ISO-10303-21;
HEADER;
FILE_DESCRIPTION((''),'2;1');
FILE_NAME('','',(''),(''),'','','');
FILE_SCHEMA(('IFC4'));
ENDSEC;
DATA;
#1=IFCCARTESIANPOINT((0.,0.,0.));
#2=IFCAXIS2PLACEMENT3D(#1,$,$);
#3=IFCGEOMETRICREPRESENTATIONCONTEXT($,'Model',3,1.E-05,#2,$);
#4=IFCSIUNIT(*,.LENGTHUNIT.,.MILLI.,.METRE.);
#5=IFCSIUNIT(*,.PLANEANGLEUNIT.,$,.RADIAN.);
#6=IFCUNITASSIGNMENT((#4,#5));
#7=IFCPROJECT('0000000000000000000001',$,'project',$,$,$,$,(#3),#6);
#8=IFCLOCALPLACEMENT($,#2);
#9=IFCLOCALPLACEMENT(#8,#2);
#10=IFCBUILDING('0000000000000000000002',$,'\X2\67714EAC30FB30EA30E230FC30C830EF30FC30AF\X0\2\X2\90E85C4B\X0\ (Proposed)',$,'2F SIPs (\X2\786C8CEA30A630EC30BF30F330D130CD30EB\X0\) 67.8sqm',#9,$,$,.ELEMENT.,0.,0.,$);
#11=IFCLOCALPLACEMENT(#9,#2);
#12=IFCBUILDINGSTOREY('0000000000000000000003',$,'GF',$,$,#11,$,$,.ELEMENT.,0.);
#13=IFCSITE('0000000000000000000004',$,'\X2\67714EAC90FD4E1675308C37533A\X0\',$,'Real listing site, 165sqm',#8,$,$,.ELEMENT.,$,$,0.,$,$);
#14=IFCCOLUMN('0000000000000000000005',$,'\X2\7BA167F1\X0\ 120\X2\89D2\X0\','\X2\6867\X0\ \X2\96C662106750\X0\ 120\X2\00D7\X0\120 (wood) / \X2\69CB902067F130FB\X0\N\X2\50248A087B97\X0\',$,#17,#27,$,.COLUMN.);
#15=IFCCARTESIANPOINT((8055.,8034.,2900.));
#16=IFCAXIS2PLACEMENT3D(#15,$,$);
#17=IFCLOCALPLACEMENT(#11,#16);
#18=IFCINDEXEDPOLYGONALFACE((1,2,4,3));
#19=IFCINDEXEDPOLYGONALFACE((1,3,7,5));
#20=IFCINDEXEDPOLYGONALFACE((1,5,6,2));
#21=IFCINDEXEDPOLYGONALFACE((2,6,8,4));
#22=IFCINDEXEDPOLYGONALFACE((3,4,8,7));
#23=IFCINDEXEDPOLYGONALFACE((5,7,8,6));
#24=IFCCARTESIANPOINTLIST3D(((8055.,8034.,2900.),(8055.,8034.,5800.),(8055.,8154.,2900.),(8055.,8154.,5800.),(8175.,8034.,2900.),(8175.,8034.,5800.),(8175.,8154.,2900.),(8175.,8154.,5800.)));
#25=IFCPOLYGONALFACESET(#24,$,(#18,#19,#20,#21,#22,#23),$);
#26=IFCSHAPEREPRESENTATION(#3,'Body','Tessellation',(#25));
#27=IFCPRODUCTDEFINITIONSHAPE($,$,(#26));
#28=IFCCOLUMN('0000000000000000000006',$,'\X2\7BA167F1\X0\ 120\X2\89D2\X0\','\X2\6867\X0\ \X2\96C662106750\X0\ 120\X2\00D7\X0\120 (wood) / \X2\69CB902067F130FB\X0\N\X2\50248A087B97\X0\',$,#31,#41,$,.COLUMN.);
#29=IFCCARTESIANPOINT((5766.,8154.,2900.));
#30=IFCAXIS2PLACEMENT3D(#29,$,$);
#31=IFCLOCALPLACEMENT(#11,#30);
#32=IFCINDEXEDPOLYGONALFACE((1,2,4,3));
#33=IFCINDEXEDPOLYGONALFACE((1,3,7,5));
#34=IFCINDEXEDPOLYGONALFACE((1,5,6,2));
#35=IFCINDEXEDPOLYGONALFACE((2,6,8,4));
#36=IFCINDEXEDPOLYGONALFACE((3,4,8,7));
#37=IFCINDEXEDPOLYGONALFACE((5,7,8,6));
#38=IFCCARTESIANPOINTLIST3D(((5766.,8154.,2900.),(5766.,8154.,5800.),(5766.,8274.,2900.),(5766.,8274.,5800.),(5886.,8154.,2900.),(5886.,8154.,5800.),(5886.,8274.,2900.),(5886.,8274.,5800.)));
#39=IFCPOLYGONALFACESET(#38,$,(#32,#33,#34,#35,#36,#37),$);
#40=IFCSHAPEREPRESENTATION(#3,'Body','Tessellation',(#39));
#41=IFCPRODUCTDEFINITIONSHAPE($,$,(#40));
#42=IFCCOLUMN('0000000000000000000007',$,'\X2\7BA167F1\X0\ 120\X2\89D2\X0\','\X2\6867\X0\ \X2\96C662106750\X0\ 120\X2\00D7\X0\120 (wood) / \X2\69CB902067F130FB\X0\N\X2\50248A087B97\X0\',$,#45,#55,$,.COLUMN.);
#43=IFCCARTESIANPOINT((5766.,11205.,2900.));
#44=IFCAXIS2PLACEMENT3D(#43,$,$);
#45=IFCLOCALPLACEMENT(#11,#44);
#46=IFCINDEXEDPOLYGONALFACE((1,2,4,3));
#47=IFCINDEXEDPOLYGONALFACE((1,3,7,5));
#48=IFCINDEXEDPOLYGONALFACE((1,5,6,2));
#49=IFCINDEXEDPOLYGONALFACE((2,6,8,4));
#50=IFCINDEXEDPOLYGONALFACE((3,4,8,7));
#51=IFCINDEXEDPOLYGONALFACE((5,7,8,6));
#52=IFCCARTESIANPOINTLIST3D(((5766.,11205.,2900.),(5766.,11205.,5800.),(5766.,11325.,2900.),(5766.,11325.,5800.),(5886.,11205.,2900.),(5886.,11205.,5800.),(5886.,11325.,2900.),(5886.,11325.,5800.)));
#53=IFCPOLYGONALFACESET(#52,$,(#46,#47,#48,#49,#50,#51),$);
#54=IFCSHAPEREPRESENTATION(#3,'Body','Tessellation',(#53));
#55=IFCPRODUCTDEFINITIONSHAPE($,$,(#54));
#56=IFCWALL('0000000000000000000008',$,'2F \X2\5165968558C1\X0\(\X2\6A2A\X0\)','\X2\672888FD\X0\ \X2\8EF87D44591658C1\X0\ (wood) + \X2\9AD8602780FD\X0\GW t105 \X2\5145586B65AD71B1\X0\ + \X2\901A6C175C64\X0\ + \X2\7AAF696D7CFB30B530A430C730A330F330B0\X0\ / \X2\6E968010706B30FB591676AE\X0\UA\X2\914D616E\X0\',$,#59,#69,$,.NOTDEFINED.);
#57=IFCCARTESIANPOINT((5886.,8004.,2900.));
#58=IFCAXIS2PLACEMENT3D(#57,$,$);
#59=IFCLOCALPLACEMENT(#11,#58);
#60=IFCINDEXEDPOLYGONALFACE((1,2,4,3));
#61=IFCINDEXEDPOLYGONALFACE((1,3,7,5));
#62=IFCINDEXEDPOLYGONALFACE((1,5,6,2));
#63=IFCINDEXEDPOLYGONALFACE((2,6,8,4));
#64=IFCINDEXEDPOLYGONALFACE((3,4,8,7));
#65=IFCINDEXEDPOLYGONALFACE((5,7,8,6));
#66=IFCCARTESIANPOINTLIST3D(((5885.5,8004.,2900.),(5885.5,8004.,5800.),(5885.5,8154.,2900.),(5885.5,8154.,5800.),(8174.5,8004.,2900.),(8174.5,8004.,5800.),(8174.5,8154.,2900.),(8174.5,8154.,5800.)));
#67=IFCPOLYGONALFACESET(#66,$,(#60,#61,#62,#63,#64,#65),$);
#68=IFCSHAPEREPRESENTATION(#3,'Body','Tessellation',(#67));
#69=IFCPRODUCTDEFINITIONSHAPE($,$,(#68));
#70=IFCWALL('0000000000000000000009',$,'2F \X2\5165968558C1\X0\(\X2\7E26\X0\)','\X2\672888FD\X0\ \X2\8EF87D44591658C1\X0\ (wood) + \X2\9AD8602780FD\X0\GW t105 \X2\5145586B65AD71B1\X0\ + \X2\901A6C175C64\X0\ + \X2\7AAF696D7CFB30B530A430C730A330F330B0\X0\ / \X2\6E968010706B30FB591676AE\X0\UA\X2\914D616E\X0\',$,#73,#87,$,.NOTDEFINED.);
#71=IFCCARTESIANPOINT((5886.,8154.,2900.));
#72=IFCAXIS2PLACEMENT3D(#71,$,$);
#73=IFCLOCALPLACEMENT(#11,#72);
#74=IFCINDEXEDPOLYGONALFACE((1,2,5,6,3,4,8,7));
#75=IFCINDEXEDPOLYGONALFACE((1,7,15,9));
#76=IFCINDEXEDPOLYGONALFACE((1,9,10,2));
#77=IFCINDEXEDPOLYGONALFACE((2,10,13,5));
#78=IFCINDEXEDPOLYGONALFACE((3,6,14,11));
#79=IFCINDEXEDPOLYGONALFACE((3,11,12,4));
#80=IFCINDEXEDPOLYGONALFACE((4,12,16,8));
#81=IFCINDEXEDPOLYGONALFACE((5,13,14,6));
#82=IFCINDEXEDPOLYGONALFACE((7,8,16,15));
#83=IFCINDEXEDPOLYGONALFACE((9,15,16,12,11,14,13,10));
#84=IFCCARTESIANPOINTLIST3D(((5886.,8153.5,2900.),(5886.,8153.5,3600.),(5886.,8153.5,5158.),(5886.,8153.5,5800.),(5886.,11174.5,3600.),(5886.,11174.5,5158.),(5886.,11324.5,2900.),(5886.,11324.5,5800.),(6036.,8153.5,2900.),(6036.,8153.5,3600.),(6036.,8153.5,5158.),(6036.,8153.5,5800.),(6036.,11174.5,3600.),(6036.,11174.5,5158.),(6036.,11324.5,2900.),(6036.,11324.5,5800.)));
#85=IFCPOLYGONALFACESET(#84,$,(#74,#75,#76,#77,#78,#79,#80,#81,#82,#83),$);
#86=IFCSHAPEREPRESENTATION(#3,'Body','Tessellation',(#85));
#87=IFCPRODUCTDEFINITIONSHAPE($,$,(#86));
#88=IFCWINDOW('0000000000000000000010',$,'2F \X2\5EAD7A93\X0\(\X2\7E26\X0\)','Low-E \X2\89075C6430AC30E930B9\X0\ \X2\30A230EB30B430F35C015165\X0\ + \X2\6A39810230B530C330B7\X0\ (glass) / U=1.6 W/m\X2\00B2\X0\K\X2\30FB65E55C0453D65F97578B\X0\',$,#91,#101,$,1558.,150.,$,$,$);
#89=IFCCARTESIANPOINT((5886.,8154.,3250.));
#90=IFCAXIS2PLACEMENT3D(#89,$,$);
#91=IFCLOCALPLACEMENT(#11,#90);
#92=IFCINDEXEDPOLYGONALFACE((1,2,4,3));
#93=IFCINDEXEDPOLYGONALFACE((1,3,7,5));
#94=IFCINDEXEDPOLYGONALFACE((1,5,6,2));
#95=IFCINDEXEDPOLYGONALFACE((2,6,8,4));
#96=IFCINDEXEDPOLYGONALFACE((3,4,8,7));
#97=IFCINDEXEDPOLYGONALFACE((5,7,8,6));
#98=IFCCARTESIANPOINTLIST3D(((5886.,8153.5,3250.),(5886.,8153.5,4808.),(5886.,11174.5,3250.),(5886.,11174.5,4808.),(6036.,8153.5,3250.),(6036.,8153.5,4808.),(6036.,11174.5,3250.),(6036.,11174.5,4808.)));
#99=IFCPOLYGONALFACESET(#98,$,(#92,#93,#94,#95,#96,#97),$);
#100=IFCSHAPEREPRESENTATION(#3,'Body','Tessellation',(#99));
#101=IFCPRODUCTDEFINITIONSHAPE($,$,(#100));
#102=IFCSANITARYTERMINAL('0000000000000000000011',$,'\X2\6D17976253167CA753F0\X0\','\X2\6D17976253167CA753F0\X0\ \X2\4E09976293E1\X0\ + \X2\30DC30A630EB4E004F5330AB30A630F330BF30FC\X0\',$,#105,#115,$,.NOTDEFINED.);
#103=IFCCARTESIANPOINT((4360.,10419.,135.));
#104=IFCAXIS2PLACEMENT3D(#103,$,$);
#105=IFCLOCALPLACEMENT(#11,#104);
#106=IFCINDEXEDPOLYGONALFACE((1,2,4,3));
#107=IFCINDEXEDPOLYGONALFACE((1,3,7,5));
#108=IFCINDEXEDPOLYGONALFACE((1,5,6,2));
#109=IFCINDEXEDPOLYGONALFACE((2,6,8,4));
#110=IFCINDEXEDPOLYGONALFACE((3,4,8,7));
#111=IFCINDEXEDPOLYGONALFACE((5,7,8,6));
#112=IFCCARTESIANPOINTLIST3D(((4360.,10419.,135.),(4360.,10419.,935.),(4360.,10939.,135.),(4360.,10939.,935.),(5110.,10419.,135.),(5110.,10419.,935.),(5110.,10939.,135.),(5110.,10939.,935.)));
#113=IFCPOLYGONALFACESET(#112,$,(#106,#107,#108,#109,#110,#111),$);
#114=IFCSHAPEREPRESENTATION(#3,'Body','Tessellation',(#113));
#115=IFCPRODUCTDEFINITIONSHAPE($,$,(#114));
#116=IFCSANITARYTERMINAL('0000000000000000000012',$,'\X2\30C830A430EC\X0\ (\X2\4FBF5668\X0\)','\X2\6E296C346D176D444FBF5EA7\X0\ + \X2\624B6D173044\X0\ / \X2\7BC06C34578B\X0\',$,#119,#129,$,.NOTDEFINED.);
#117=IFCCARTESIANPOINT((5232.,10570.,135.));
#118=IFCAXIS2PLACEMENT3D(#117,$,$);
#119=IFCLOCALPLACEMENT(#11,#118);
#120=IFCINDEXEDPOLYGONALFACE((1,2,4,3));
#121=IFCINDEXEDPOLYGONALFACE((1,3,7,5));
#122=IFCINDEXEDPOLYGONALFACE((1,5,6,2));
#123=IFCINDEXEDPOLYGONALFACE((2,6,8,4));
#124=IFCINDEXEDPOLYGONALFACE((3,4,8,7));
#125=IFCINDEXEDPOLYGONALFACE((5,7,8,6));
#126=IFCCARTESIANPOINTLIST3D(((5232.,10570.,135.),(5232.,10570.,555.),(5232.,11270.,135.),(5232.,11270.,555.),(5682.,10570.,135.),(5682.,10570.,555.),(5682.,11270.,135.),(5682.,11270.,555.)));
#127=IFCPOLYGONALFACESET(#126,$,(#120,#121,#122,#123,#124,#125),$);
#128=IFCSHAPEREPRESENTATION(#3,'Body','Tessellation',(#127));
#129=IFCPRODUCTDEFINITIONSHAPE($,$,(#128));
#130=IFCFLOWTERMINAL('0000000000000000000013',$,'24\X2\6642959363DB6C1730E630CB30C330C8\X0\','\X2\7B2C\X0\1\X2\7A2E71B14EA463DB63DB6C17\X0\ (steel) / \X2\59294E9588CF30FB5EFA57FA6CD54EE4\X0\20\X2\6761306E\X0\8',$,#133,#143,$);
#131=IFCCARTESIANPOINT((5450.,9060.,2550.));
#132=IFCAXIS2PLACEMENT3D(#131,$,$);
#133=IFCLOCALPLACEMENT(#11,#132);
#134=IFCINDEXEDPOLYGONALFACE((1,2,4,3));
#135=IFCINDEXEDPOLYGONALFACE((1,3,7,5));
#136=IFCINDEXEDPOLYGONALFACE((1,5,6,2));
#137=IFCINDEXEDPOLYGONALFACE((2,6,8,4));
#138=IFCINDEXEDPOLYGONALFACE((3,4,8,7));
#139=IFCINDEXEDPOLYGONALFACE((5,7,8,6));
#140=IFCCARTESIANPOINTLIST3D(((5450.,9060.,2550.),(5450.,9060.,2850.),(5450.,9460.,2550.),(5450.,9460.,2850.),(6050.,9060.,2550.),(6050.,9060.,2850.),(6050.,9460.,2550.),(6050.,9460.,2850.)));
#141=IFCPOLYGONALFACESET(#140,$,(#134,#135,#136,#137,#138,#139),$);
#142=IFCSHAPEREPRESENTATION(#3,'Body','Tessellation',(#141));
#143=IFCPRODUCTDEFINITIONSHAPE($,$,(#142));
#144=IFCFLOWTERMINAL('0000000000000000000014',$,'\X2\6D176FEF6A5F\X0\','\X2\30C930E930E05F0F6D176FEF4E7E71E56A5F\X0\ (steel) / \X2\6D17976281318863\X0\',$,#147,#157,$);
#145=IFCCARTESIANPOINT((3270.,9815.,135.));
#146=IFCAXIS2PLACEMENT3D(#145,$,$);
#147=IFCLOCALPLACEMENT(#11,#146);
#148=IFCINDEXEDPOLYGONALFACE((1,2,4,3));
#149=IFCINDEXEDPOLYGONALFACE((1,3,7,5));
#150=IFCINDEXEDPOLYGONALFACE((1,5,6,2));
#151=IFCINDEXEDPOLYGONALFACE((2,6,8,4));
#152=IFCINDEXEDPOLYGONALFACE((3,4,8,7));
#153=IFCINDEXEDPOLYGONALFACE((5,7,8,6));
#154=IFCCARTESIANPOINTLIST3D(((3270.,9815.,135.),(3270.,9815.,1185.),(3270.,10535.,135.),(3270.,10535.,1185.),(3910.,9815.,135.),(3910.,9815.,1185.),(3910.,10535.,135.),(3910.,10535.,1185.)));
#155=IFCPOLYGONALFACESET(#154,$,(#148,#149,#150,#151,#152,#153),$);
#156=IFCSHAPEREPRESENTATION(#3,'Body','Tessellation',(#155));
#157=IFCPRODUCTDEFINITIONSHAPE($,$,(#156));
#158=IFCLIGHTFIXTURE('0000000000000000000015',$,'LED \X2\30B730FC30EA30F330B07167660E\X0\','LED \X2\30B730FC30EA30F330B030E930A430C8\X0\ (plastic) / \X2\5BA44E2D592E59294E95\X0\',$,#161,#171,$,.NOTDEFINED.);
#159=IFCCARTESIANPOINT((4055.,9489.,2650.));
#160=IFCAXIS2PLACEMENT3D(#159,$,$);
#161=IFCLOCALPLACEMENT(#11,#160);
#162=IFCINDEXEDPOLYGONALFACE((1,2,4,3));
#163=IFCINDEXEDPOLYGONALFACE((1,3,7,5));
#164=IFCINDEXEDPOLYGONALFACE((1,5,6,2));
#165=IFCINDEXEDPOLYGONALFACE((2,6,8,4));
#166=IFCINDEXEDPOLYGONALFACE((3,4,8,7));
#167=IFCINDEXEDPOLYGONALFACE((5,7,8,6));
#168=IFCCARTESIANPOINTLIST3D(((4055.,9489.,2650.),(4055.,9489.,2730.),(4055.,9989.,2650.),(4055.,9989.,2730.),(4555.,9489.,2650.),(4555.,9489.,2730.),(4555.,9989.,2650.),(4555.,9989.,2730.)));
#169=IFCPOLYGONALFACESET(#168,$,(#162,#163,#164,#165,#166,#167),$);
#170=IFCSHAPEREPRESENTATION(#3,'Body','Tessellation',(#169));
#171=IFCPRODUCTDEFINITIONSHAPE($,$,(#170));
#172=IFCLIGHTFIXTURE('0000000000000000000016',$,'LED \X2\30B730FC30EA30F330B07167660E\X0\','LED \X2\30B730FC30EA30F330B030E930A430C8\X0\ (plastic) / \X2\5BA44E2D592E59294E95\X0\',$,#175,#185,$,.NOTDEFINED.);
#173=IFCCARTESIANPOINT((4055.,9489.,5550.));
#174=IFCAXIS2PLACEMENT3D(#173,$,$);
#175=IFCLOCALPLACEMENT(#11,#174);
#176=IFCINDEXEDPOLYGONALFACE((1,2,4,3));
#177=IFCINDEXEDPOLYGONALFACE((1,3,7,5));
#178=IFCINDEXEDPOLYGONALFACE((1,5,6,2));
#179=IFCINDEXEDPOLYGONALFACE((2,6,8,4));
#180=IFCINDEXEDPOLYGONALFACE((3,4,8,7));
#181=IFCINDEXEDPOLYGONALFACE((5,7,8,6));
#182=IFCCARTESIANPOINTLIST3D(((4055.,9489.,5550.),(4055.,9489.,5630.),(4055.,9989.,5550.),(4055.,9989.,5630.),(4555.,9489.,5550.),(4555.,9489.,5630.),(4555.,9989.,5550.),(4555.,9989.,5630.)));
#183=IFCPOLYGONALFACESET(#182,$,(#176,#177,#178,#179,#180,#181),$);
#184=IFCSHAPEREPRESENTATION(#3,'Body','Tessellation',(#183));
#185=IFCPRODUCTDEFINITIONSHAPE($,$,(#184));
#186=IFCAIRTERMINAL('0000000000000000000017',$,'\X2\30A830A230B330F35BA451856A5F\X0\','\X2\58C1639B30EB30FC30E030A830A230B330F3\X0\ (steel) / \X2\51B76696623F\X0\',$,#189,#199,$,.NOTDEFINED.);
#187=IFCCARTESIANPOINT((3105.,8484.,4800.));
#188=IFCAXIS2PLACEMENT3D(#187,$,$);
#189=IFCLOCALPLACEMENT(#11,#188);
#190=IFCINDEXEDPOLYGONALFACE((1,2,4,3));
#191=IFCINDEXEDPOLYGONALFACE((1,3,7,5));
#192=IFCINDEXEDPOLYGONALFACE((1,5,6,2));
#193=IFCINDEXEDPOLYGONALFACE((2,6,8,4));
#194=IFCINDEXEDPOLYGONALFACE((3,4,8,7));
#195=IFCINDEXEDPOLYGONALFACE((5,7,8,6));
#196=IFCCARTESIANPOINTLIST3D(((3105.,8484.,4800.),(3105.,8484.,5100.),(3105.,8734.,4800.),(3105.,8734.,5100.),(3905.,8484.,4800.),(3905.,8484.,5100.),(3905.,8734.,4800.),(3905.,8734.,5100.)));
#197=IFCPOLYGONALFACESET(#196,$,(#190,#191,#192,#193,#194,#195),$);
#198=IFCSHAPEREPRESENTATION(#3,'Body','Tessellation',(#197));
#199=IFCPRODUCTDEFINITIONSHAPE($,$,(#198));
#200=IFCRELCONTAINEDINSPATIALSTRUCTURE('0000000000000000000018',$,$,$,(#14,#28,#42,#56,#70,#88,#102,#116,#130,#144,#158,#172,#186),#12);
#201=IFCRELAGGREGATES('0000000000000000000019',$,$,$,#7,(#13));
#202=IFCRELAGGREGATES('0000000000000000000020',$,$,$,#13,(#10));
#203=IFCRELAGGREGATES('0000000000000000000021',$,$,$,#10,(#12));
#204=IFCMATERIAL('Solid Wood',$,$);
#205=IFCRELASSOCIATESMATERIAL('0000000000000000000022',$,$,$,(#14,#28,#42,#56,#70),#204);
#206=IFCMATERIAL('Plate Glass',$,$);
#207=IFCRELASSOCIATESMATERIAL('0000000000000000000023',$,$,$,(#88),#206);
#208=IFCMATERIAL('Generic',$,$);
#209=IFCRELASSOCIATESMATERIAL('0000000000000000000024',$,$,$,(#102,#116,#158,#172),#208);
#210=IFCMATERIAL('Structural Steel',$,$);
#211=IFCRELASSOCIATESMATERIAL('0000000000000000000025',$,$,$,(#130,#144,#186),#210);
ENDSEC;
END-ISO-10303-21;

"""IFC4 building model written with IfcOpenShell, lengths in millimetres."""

from ifc_helpers import new_model, si_unit, frame, frame_2d, origin, place, context, project, spatial, rectangle, extrude, material, element, fill, save


model = new_model("IFC4")

# Units and contexts
model_context = context("Model", 3, precision=1e-05, world=origin())
ifc_project = project(units=[si_unit("LENGTHUNIT", "METRE", prefix="MILLI"), si_unit("PLANEANGLEUNIT", "RADIAN")], contexts=[model_context])

# Site, building, storey
site_placement = place(None, origin())
site = spatial("IfcSite", under=ifc_project, at=site_placement, Name="東京都世田谷区", ObjectType="Real listing site, 165sqm", CompositionType="ELEMENT", RefElevation=0.0)
building_placement = place(site_placement, origin())
building = spatial("IfcBuilding", under=site, at=building_placement, Name="東京・リモートワーク2部屋 (Proposed)", ObjectType="2F SIPs (硬質ウレタンパネル) 67.8sqm", CompositionType="ELEMENT", ElevationOfRefHeight=0.0, ElevationOfTerrain=0.0)
storey_placement = place(building_placement, origin())
storey = spatial("IfcBuildingStorey", under=building, at=storey_placement, Name="GF", CompositionType="ELEMENT", Elevation=0.0)

# Columns
ifc_material_1 = material(Name="Solid Wood")
column_1_placement = place(storey_placement, frame((8055.0, 8034.0, 2900.0)))
element("IfcColumn", 1, at=column_1_placement, inside=storey, material=ifc_material_1, Name="管柱 120角", Description="桧 集成材 120×120 (wood) / 構造柱・N値計算", PredefinedType="COLUMN", context=model_context, shape_type="SweptSolid", body=[
    extrude(rectangle(XDim=120.0, YDim=120.0, at=frame_2d((60.0, 60.0))), frame((8055.0, 8034.0, 2900.0)), (0.0, 0.0, 1.0), 2900.0),
])
column_2_placement = place(storey_placement, frame((5766.0, 8154.0, 2900.0)))
element("IfcColumn", 2, at=column_2_placement, inside=storey, material=ifc_material_1, Name="管柱 120角", Description="桧 集成材 120×120 (wood) / 構造柱・N値計算", PredefinedType="COLUMN", context=model_context, shape_type="SweptSolid", body=[
    extrude(rectangle(XDim=120.0, YDim=120.0, at=frame_2d((60.0, 60.0))), frame((5766.0, 8154.0, 2900.0)), (0.0, 0.0, 1.0), 2900.0),
])
column_3_placement = place(storey_placement, frame((5766.0, 11205.0, 2900.0)))
element("IfcColumn", 3, at=column_3_placement, inside=storey, material=ifc_material_1, Name="管柱 120角", Description="桧 集成材 120×120 (wood) / 構造柱・N値計算", PredefinedType="COLUMN", context=model_context, shape_type="SweptSolid", body=[
    extrude(rectangle(XDim=120.0, YDim=120.0, at=frame_2d((60.0, 60.0))), frame((5766.0, 11205.0, 2900.0)), (0.0, 0.0, 1.0), 2900.0),
])

# Wall
wall_1_placement = place(storey_placement, frame((5886.0, 8004.0, 2900.0)))
element("IfcWall", 4, at=wall_1_placement, inside=storey, material=ifc_material_1, Name="2F 入隅壁(横)", Description="木製 軸組外壁 (wood) + 高性能GW t105 充填断熱 + 通気層 + 窯業系サイディング / 準耐火・外皮UA配慮", PredefinedType="NOTDEFINED", context=model_context, shape_type="SweptSolid", body=[
    extrude(rectangle(XDim=2289.0, YDim=150.0, at=frame_2d((1144.0, 75.0))), frame((5886.0, 8004.0, 2900.0)), (0.0, 0.0, 1.0), 2900.0),
])

# Wall, opening, window
wall_2_placement = place(storey_placement, frame((5886.0, 8154.0, 2900.0)))
wall_2 = element("IfcWall", 5, at=wall_2_placement, inside=storey, material=ifc_material_1, Name="2F 入隅壁(縦)", Description="木製 軸組外壁 (wood) + 高性能GW t105 充填断熱 + 通気層 + 窯業系サイディング / 準耐火・外皮UA配慮", PredefinedType="NOTDEFINED", context=model_context, shape_type="SweptSolid", body=[
    extrude(rectangle(XDim=150.0, YDim=3171.0, at=frame_2d((75.0, 1585.0))), frame((5886.0, 8154.0, 2900.0)), (0.0, 0.0, 1.0), 2900.0),
])
opening_placement = place(storey_placement, frame((5886.0, 8154.0, 3250.0)))
opening = element("IfcOpeningElement", 6, at=opening_placement, cuts=wall_2, PredefinedType="NOTDEFINED", context=model_context, shape_type="SweptSolid", body=[
    extrude(rectangle(XDim=150.0, YDim=3021.0, at=frame_2d((75.0, 1510.0))), frame((5886.0, 8154.0, 3250.0)), (0.0, 0.0, 1.0), 1558.0),
])
ifc_material_2 = material(Name="Plate Glass")
window_placement = place(storey_placement, frame((5886.0, 8154.0, 3250.0)))
window = element("IfcWindow", 7, at=window_placement, inside=storey, material=ifc_material_2, Name="2F 庭窓(縦)", Description="Low-E 複層ガラス アルゴン封入 + 樹脂サッシ (glass) / U=1.6 W/m²K・日射取得型", OverallHeight=1558.0, OverallWidth=150.0, context=model_context, shape_type="SweptSolid", body=[
    extrude(rectangle(XDim=150.0, YDim=3021.0, at=frame_2d((75.0, 1510.0))), frame((5886.0, 8154.0, 3250.0)), (0.0, 0.0, 1.0), 1558.0),
])
fill(opening, window)

# Sanitary terminals
ifc_material_3 = material(Name="Generic")
sanitary_terminal_1_placement = place(storey_placement, frame((4360.0, 10419.0, 135.0)))
element("IfcSanitaryTerminal", 8, at=sanitary_terminal_1_placement, inside=storey, material=ifc_material_3, Name="洗面化粧台", Description="洗面化粧台 三面鏡 + ボウル一体カウンター", PredefinedType="NOTDEFINED", context=model_context, shape_type="SweptSolid", body=[
    extrude(rectangle(XDim=750.0, YDim=520.0, at=frame_2d((375.0, 260.0))), frame((4360.0, 10419.0, 135.0)), (0.0, 0.0, 1.0), 800.0),
])
sanitary_terminal_2_placement = place(storey_placement, frame((5232.0, 10570.0, 135.0)))
element("IfcSanitaryTerminal", 9, at=sanitary_terminal_2_placement, inside=storey, material=ifc_material_3, Name="トイレ (便器)", Description="温水洗浄便座 + 手洗い / 節水型", PredefinedType="NOTDEFINED", context=model_context, shape_type="SweptSolid", body=[
    extrude(rectangle(XDim=450.0, YDim=700.0, at=frame_2d((225.0, 350.0))), frame((5232.0, 10570.0, 135.0)), (0.0, 0.0, 1.0), 420.0),
])

# Flow terminals
ifc_material_4 = material(Name="Structural Steel")
flow_terminal_1_placement = place(storey_placement, frame((5450.0, 9060.0, 2550.0)))
element("IfcFlowTerminal", 10, at=flow_terminal_1_placement, inside=storey, material=ifc_material_4, Name="24時間換気ユニット", Description="第1種熱交換換気 (steel) / 天井裏・建基法令20条の8", context=model_context, shape_type="SweptSolid", body=[
    extrude(rectangle(XDim=600.0, YDim=400.0, at=frame_2d((300.0, 200.0))), frame((5450.0, 9060.0, 2550.0)), (0.0, 0.0, 1.0), 300.0),
])
flow_terminal_2_placement = place(storey_placement, frame((3270.0, 9815.0, 135.0)))
element("IfcFlowTerminal", 11, at=flow_terminal_2_placement, inside=storey, material=ifc_material_4, Name="洗濯機", Description="ドラム式洗濯乾燥機 (steel) / 洗面脱衣", context=model_context, shape_type="SweptSolid", body=[
    extrude(rectangle(XDim=640.0, YDim=720.0, at=frame_2d((320.0, 360.0))), frame((3270.0, 9815.0, 135.0)), (0.0, 0.0, 1.0), 1050.0),
])

# Light fixtures
light_fixture_1_placement = place(storey_placement, frame((4055.0, 9489.0, 2650.0)))
element("IfcLightFixture", 12, at=light_fixture_1_placement, inside=storey, material=ifc_material_3, Name="LED シーリング照明", Description="LED シーリングライト (plastic) / 室中央天井", PredefinedType="NOTDEFINED", context=model_context, shape_type="SweptSolid", body=[
    extrude(rectangle(XDim=500.0, YDim=500.0, at=frame_2d((250.0, 250.0))), frame((4055.0, 9489.0, 2650.0)), (0.0, 0.0, 1.0), 80.0),
])
light_fixture_2_placement = place(storey_placement, frame((4055.0, 9489.0, 5550.0)))
element("IfcLightFixture", 13, at=light_fixture_2_placement, inside=storey, material=ifc_material_3, Name="LED シーリング照明", Description="LED シーリングライト (plastic) / 室中央天井", PredefinedType="NOTDEFINED", context=model_context, shape_type="SweptSolid", body=[
    extrude(rectangle(XDim=500.0, YDim=500.0, at=frame_2d((250.0, 250.0))), frame((4055.0, 9489.0, 5550.0)), (0.0, 0.0, 1.0), 80.0),
])

# Air terminal
air_terminal_placement = place(storey_placement, frame((3105.0, 8484.0, 4800.0)))
element("IfcAirTerminal", 14, at=air_terminal_placement, inside=storey, material=ifc_material_4, Name="エアコン室内機", Description="壁掛ルームエアコン (steel) / 冷暖房", PredefinedType="NOTDEFINED", context=model_context, shape_type="SweptSolid", body=[
    extrude(rectangle(XDim=800.0, YDim=250.0, at=frame_2d((400.0, 125.0))), frame((3105.0, 8484.0, 4800.0)), (0.0, 0.0, 1.0), 300.0),
])

save(model, "model.ifc")
